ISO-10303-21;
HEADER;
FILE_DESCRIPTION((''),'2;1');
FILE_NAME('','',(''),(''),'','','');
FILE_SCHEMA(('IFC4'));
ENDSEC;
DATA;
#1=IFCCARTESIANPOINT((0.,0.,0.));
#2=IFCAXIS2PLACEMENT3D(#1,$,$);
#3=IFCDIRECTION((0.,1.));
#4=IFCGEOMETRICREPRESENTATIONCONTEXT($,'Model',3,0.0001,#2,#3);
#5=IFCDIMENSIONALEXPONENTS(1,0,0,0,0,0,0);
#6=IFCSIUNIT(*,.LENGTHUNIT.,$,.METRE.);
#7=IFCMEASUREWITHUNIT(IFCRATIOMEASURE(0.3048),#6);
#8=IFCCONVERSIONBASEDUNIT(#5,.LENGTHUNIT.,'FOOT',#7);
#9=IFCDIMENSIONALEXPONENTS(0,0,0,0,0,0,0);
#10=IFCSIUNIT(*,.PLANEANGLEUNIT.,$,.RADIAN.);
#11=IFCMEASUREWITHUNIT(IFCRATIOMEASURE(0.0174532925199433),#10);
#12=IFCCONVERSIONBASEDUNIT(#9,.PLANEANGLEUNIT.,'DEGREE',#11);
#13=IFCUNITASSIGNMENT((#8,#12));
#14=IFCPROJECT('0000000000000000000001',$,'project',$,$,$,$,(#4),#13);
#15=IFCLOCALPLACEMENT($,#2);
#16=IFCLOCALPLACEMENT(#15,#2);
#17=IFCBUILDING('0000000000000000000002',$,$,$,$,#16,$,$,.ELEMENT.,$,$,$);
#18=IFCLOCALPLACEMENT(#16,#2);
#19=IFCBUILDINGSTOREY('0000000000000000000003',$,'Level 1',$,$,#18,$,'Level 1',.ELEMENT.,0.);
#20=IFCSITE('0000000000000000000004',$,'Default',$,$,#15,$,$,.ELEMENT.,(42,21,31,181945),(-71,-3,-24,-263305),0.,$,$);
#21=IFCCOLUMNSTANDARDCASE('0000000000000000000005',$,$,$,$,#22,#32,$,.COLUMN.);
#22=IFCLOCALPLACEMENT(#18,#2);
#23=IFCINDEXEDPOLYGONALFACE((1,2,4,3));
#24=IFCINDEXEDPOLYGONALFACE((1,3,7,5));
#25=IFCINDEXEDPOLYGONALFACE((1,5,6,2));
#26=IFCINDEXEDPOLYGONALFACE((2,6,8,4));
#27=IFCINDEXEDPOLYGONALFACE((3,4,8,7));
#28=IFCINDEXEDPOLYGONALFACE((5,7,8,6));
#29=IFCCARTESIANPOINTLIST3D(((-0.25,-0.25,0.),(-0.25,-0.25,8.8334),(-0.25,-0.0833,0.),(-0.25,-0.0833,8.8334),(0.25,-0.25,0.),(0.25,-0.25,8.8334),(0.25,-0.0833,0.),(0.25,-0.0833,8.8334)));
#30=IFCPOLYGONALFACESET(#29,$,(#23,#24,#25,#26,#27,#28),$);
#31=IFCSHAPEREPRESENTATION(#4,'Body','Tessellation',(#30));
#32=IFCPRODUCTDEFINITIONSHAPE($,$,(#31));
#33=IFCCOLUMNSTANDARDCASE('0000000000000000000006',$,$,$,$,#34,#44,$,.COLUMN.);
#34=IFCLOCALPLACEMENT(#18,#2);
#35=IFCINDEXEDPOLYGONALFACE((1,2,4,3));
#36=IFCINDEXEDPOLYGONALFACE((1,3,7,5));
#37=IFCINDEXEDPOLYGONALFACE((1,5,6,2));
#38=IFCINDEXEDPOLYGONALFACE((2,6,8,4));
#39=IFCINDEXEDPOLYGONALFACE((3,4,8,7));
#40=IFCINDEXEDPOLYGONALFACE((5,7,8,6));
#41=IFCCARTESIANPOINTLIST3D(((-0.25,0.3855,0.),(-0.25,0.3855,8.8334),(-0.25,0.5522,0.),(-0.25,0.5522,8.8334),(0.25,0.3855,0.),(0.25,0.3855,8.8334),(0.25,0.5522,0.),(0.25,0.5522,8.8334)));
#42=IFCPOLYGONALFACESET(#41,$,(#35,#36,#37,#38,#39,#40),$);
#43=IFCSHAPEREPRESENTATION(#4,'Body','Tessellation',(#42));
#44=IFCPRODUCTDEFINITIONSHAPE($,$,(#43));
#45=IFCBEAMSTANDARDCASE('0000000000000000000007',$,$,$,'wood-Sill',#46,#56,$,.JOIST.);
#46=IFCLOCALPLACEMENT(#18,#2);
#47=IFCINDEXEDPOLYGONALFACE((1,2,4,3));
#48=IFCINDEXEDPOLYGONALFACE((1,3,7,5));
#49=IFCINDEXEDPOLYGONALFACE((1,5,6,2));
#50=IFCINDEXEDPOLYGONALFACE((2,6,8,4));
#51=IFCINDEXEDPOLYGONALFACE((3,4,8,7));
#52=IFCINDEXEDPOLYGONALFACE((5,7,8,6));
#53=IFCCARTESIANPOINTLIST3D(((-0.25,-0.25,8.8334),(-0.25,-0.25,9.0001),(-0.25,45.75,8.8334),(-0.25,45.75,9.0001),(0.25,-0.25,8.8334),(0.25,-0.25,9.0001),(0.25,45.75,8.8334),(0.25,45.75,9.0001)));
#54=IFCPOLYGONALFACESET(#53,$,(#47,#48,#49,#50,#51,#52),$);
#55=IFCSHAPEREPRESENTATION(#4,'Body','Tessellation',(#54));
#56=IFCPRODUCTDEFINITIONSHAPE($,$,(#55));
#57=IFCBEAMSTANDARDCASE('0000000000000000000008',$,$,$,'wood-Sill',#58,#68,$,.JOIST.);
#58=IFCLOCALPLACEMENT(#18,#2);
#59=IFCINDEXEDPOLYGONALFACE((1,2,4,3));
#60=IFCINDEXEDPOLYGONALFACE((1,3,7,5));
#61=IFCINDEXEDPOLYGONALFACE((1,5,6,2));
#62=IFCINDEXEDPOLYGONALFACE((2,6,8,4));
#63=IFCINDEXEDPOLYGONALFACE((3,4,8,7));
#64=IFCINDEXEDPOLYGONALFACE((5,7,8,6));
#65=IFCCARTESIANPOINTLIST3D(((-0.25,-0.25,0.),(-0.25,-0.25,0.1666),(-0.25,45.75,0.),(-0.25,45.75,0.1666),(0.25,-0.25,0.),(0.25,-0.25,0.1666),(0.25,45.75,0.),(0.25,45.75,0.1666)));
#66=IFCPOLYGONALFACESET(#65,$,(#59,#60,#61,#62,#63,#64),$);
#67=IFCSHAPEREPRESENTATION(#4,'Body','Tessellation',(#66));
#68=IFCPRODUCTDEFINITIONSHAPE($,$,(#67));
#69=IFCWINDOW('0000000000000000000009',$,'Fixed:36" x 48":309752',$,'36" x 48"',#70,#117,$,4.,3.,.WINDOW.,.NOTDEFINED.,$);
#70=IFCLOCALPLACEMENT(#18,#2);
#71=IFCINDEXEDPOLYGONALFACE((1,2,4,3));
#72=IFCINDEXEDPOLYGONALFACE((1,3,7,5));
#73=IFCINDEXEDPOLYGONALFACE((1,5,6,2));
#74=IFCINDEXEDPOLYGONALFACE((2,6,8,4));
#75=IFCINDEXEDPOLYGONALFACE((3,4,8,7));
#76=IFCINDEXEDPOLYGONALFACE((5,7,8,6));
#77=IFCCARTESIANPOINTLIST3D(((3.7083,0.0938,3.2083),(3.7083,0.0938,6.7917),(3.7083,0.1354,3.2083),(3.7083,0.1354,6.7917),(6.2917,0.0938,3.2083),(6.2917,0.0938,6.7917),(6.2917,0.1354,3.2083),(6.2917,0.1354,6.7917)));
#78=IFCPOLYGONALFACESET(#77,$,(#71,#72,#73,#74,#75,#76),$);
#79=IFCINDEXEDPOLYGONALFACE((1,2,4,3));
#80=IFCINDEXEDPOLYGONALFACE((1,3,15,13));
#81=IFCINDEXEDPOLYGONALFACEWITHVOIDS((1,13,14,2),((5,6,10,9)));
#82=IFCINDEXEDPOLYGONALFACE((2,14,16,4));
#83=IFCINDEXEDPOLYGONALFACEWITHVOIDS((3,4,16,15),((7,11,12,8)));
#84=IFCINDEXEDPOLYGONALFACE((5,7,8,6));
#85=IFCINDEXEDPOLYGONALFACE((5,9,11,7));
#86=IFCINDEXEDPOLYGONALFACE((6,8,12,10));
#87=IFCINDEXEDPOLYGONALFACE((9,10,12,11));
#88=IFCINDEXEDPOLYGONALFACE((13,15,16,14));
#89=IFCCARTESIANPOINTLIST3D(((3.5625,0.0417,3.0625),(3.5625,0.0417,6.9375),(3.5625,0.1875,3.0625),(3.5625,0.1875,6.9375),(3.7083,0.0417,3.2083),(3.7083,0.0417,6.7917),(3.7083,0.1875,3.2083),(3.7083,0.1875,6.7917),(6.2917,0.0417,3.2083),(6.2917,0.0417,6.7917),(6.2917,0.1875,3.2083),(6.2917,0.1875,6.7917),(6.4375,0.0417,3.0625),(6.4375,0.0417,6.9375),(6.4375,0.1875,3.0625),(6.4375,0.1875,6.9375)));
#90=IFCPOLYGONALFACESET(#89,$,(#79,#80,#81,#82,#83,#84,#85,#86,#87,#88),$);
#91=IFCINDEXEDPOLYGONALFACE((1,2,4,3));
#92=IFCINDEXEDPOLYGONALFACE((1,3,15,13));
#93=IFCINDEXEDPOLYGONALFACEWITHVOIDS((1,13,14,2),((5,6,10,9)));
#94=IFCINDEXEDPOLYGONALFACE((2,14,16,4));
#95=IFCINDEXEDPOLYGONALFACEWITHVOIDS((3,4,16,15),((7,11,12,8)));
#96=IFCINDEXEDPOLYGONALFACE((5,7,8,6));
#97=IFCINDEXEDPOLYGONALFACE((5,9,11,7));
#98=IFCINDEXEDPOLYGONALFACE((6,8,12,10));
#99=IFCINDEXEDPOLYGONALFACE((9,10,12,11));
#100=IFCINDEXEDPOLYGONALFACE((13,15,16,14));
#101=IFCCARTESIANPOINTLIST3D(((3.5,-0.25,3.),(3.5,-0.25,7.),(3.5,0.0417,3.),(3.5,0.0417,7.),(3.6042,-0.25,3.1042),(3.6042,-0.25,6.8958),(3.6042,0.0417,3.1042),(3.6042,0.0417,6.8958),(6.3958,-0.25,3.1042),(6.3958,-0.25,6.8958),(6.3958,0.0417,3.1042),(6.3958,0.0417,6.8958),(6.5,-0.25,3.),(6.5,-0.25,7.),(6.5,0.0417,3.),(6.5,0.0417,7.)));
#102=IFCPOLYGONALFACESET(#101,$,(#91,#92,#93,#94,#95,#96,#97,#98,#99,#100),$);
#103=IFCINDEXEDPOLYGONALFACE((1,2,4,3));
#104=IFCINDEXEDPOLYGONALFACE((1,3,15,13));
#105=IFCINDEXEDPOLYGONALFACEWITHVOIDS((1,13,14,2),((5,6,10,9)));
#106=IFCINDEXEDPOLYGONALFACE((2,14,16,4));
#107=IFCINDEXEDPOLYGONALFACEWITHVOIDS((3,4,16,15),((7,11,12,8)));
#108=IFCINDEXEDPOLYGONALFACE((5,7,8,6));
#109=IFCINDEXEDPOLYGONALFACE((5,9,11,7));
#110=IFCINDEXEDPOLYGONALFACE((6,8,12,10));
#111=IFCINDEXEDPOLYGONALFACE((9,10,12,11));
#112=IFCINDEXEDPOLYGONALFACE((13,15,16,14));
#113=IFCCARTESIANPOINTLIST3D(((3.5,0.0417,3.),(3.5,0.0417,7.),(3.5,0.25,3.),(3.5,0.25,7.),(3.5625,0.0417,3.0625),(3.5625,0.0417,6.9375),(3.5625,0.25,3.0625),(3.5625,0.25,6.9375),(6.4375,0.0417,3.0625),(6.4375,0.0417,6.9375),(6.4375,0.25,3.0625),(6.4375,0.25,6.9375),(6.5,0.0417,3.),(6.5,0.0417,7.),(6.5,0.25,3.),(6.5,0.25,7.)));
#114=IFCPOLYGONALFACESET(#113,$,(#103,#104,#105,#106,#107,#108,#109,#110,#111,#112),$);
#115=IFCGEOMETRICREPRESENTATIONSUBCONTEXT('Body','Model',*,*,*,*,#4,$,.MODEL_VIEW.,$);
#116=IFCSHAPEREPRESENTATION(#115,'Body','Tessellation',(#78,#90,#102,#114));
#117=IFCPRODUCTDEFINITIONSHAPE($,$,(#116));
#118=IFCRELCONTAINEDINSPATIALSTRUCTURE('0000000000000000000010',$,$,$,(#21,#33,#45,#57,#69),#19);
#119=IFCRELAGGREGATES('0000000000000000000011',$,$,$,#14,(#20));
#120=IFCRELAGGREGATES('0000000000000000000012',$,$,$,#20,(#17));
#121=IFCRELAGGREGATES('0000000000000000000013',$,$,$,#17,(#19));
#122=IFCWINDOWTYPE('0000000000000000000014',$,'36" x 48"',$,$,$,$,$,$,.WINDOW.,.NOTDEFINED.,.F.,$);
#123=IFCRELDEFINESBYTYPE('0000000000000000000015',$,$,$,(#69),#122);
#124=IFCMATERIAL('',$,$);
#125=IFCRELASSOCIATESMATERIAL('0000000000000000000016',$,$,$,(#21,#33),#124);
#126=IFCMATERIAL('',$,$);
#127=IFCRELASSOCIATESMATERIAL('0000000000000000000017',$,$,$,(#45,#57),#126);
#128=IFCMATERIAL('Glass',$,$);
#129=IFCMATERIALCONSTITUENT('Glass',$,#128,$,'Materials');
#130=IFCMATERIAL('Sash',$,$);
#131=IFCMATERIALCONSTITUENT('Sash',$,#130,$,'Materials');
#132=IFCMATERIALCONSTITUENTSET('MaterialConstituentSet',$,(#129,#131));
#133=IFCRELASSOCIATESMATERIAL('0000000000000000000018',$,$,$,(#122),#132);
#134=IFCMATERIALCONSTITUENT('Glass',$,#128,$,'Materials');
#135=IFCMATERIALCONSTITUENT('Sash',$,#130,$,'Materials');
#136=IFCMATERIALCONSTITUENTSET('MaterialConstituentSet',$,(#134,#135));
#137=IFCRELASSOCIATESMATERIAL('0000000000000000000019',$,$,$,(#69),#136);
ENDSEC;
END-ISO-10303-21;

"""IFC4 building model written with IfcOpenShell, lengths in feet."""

from ifc_helpers import new_model, entity, si_unit, converted_unit, direction, frame, frame_2d, origin, origin_with_axes, place, context, subcontext, project, spatial, polyline, rectangle, outline, extrude, source, transform, mapped, material, constituent, constituent_set, type_object, type_shapes, element, save


model = new_model("IFC4")

# Units and contexts
model_context = context("Model", 3, precision=0.0001, world=origin(), true_north=direction((0.0, 1.0)))
body_context = subcontext(model_context, "Body", "Model", "MODEL_VIEW")
ifc_project = project(units=[converted_unit("LENGTHUNIT", "FOOT", entity("IfcRatioMeasure", 0.3048), si_unit("LENGTHUNIT", "METRE"), dimensions=[1, 0, 0, 0, 0, 0, 0]), converted_unit("PLANEANGLEUNIT", "DEGREE", entity("IfcRatioMeasure", 0.0174532925199433), si_unit("PLANEANGLEUNIT", "RADIAN"), dimensions=[0, 0, 0, 0, 0, 0, 0])], contexts=[model_context])

# Site, building, storey
site_placement = place(None, origin())
site = spatial("IfcSite", under=ifc_project, at=site_placement, Name="Default", CompositionType="ELEMENT", RefLatitude=(42, 21, 31, 181945), RefLongitude=(-71, -3, -24, -263305), RefElevation=0.0)
building_placement = place(site_placement, origin())
building = spatial("IfcBuilding", under=site, at=building_placement, CompositionType="ELEMENT")
storey_placement = place(building_placement, origin())
storey = spatial("IfcBuildingStorey", under=building, at=storey_placement, Name="Level 1", LongName="Level 1", CompositionType="ELEMENT", Elevation=0.0)

# Columns
ifc_material_1 = material(Name="")
placement_1 = place(storey_placement, frame((0.0, -0.25, 0.0), z_axis=(0.0, 0.0, 1.0), x_axis=(0.0, 1.0, 0.0)))
for number, where, z_axis, x_axis in (
    (1, (0.0833, 0.0, 0.0), (0.0, 0.0, 1.0), (1.0, 0.0, 0.0)),
    (2, (0.7188, 0.0, 0.0), (0.0, 0.0, 1.0), (1.0, 0.0, 0.0)),
):
    element("IfcColumnStandardCase", number, at=place(placement_1, frame(where, z_axis=z_axis, x_axis=x_axis)), inside=storey, material=ifc_material_1, PredefinedType="COLUMN", context=model_context, shape_type="SweptSolid", body=[
        extrude(rectangle(XDim=0.1667, YDim=0.5), origin(), (0.0, 0.0, 1.0), 8.8334),
    ])
placement_2 = place(storey_placement, frame((46.25, 0.0, 0.0), z_axis=(0.0, 0.0, 1.0), x_axis=(-1.0, 0.0, 0.0)))

# Beams
ifc_material_2 = material(Name="")
for number, where, z_axis, x_axis in (
    (3, (0.0, 0.0, 8.9167), (1.0, 0.0, 0.0), (0.0, 0.0, 1.0)),
    (4, (0.0, 0.0, 0.0833), (1.0, 0.0, 0.0), (0.0, 0.0, 1.0)),
):
    element("IfcBeamStandardCase", number, at=place(placement_1, frame(where, z_axis=z_axis, x_axis=x_axis)), inside=storey, material=ifc_material_2, ObjectType="wood-Sill", PredefinedType="JOIST", context=model_context, shape_type="SweptSolid", body=[
        extrude(rectangle(XDim=0.1667, YDim=0.5), origin_with_axes(), (0.0, 0.0, 1.0), 46.0),
    ])

# Window
ifc_material_3 = material(Name="Glass")
ifc_constituent_1 = constituent(ifc_material_3, Name="Glass", Category="Materials")
ifc_material_4 = material(Name="Sash")
ifc_constituent_2 = constituent(ifc_material_4, Name="Sash", Category="Materials")
ifc_constituent_set_1 = constituent_set(constituents=[ifc_constituent_1, ifc_constituent_2], Name="MaterialConstituentSet")
ifc_constituent_3 = constituent(ifc_material_3, Name="Glass", Category="Materials")
ifc_constituent_4 = constituent(ifc_material_4, Name="Sash", Category="Materials")
ifc_constituent_set_2 = constituent_set(constituents=[ifc_constituent_3, ifc_constituent_4], Name="MaterialConstituentSet")
window_type = type_object("IfcWindowType", Name="36\" x 48\"", ParameterTakesPrecedence=False, PartitioningType="NOTDEFINED", PredefinedType="WINDOW", material=ifc_constituent_set_2)
shared_shape = source(origin(), body_context, "Body", "SweptSolid", [
    extrude(rectangle(XDim=0.0417, YDim=2.5833, at=frame_2d((0.0, 0.0), x_axis=(1.0, 0.0))), frame((1.5, 0.3646, 0.2083), z_axis=(0.0, 0.0, 1.0), x_axis=(0.0, 1.0, 0.0)), (0.0, 0.0, 1.0), 3.5833),
    extrude(outline(polyline([(-1.4375, -1.9375), (1.4375, -1.9375), (1.4375, 1.9375), (-1.4375, 1.9375), (-1.4375, -1.9375)]), holes=[polyline([(-1.2917, -1.7917), (-1.2917, 1.7917), (1.2917, 1.7917), (1.2917, -1.7917), (-1.2917, -1.7917)])]), frame((1.5, 0.2917, 2.0), z_axis=(0.0, 1.0, 0.0), x_axis=(1.0, 0.0, 0.0)), (0.0, 0.0, 1.0), 0.1458),
    extrude(outline(polyline([(-1.5, -2.0), (1.5, -2.0), (1.5, 2.0), (-1.5, 2.0), (-1.5, -2.0)]), holes=[polyline([(-1.3958, -1.8958), (-1.3958, 1.8958), (1.3958, 1.8958), (1.3958, -1.8958), (-1.3958, -1.8958)])]), frame((1.5, 0.0, 2.0), z_axis=(0.0, 1.0, 0.0), x_axis=(1.0, 0.0, 0.0)), (0.0, 0.0, 1.0), 0.2917),
    extrude(outline(polyline([(-2.0, -1.5), (2.0, -1.5), (2.0, 1.5), (-2.0, 1.5), (-2.0, -1.5)]), holes=[polyline([(-1.9375, -1.4375), (-1.9375, 1.4375), (1.9375, 1.4375), (1.9375, -1.4375), (-1.9375, -1.4375)])]), frame((1.5, 0.2917, 2.0), z_axis=(0.0, 1.0, 0.0), x_axis=(0.0, 0.0, -1.0)), (0.0, 0.0, 1.0), 0.2083),
])
type_shapes(window_type, [shared_shape])
placement_3 = place(placement_2, frame((42.75, 0.25, 3.0)))
window_placement = place(placement_3, frame((0.0, 0.0, 0.0), z_axis=(0.0, 0.0, 1.0), x_axis=(-1.0, 0.0, 0.0)))
element("IfcWindow", 5, at=window_placement, inside=storey, type_object=window_type, material=ifc_constituent_set_1, Name="Fixed:36\" x 48\":309752", ObjectType="36\" x 48\"", OverallHeight=4.0, OverallWidth=3.0, PartitioningType="NOTDEFINED", PredefinedType="WINDOW", context=body_context, shape_type="MappedRepresentation", body=[
    mapped(shared_shape, transform((0.0, 0.0, 0.0), scale=1.0)),
])

save(model, "model.ifc")
